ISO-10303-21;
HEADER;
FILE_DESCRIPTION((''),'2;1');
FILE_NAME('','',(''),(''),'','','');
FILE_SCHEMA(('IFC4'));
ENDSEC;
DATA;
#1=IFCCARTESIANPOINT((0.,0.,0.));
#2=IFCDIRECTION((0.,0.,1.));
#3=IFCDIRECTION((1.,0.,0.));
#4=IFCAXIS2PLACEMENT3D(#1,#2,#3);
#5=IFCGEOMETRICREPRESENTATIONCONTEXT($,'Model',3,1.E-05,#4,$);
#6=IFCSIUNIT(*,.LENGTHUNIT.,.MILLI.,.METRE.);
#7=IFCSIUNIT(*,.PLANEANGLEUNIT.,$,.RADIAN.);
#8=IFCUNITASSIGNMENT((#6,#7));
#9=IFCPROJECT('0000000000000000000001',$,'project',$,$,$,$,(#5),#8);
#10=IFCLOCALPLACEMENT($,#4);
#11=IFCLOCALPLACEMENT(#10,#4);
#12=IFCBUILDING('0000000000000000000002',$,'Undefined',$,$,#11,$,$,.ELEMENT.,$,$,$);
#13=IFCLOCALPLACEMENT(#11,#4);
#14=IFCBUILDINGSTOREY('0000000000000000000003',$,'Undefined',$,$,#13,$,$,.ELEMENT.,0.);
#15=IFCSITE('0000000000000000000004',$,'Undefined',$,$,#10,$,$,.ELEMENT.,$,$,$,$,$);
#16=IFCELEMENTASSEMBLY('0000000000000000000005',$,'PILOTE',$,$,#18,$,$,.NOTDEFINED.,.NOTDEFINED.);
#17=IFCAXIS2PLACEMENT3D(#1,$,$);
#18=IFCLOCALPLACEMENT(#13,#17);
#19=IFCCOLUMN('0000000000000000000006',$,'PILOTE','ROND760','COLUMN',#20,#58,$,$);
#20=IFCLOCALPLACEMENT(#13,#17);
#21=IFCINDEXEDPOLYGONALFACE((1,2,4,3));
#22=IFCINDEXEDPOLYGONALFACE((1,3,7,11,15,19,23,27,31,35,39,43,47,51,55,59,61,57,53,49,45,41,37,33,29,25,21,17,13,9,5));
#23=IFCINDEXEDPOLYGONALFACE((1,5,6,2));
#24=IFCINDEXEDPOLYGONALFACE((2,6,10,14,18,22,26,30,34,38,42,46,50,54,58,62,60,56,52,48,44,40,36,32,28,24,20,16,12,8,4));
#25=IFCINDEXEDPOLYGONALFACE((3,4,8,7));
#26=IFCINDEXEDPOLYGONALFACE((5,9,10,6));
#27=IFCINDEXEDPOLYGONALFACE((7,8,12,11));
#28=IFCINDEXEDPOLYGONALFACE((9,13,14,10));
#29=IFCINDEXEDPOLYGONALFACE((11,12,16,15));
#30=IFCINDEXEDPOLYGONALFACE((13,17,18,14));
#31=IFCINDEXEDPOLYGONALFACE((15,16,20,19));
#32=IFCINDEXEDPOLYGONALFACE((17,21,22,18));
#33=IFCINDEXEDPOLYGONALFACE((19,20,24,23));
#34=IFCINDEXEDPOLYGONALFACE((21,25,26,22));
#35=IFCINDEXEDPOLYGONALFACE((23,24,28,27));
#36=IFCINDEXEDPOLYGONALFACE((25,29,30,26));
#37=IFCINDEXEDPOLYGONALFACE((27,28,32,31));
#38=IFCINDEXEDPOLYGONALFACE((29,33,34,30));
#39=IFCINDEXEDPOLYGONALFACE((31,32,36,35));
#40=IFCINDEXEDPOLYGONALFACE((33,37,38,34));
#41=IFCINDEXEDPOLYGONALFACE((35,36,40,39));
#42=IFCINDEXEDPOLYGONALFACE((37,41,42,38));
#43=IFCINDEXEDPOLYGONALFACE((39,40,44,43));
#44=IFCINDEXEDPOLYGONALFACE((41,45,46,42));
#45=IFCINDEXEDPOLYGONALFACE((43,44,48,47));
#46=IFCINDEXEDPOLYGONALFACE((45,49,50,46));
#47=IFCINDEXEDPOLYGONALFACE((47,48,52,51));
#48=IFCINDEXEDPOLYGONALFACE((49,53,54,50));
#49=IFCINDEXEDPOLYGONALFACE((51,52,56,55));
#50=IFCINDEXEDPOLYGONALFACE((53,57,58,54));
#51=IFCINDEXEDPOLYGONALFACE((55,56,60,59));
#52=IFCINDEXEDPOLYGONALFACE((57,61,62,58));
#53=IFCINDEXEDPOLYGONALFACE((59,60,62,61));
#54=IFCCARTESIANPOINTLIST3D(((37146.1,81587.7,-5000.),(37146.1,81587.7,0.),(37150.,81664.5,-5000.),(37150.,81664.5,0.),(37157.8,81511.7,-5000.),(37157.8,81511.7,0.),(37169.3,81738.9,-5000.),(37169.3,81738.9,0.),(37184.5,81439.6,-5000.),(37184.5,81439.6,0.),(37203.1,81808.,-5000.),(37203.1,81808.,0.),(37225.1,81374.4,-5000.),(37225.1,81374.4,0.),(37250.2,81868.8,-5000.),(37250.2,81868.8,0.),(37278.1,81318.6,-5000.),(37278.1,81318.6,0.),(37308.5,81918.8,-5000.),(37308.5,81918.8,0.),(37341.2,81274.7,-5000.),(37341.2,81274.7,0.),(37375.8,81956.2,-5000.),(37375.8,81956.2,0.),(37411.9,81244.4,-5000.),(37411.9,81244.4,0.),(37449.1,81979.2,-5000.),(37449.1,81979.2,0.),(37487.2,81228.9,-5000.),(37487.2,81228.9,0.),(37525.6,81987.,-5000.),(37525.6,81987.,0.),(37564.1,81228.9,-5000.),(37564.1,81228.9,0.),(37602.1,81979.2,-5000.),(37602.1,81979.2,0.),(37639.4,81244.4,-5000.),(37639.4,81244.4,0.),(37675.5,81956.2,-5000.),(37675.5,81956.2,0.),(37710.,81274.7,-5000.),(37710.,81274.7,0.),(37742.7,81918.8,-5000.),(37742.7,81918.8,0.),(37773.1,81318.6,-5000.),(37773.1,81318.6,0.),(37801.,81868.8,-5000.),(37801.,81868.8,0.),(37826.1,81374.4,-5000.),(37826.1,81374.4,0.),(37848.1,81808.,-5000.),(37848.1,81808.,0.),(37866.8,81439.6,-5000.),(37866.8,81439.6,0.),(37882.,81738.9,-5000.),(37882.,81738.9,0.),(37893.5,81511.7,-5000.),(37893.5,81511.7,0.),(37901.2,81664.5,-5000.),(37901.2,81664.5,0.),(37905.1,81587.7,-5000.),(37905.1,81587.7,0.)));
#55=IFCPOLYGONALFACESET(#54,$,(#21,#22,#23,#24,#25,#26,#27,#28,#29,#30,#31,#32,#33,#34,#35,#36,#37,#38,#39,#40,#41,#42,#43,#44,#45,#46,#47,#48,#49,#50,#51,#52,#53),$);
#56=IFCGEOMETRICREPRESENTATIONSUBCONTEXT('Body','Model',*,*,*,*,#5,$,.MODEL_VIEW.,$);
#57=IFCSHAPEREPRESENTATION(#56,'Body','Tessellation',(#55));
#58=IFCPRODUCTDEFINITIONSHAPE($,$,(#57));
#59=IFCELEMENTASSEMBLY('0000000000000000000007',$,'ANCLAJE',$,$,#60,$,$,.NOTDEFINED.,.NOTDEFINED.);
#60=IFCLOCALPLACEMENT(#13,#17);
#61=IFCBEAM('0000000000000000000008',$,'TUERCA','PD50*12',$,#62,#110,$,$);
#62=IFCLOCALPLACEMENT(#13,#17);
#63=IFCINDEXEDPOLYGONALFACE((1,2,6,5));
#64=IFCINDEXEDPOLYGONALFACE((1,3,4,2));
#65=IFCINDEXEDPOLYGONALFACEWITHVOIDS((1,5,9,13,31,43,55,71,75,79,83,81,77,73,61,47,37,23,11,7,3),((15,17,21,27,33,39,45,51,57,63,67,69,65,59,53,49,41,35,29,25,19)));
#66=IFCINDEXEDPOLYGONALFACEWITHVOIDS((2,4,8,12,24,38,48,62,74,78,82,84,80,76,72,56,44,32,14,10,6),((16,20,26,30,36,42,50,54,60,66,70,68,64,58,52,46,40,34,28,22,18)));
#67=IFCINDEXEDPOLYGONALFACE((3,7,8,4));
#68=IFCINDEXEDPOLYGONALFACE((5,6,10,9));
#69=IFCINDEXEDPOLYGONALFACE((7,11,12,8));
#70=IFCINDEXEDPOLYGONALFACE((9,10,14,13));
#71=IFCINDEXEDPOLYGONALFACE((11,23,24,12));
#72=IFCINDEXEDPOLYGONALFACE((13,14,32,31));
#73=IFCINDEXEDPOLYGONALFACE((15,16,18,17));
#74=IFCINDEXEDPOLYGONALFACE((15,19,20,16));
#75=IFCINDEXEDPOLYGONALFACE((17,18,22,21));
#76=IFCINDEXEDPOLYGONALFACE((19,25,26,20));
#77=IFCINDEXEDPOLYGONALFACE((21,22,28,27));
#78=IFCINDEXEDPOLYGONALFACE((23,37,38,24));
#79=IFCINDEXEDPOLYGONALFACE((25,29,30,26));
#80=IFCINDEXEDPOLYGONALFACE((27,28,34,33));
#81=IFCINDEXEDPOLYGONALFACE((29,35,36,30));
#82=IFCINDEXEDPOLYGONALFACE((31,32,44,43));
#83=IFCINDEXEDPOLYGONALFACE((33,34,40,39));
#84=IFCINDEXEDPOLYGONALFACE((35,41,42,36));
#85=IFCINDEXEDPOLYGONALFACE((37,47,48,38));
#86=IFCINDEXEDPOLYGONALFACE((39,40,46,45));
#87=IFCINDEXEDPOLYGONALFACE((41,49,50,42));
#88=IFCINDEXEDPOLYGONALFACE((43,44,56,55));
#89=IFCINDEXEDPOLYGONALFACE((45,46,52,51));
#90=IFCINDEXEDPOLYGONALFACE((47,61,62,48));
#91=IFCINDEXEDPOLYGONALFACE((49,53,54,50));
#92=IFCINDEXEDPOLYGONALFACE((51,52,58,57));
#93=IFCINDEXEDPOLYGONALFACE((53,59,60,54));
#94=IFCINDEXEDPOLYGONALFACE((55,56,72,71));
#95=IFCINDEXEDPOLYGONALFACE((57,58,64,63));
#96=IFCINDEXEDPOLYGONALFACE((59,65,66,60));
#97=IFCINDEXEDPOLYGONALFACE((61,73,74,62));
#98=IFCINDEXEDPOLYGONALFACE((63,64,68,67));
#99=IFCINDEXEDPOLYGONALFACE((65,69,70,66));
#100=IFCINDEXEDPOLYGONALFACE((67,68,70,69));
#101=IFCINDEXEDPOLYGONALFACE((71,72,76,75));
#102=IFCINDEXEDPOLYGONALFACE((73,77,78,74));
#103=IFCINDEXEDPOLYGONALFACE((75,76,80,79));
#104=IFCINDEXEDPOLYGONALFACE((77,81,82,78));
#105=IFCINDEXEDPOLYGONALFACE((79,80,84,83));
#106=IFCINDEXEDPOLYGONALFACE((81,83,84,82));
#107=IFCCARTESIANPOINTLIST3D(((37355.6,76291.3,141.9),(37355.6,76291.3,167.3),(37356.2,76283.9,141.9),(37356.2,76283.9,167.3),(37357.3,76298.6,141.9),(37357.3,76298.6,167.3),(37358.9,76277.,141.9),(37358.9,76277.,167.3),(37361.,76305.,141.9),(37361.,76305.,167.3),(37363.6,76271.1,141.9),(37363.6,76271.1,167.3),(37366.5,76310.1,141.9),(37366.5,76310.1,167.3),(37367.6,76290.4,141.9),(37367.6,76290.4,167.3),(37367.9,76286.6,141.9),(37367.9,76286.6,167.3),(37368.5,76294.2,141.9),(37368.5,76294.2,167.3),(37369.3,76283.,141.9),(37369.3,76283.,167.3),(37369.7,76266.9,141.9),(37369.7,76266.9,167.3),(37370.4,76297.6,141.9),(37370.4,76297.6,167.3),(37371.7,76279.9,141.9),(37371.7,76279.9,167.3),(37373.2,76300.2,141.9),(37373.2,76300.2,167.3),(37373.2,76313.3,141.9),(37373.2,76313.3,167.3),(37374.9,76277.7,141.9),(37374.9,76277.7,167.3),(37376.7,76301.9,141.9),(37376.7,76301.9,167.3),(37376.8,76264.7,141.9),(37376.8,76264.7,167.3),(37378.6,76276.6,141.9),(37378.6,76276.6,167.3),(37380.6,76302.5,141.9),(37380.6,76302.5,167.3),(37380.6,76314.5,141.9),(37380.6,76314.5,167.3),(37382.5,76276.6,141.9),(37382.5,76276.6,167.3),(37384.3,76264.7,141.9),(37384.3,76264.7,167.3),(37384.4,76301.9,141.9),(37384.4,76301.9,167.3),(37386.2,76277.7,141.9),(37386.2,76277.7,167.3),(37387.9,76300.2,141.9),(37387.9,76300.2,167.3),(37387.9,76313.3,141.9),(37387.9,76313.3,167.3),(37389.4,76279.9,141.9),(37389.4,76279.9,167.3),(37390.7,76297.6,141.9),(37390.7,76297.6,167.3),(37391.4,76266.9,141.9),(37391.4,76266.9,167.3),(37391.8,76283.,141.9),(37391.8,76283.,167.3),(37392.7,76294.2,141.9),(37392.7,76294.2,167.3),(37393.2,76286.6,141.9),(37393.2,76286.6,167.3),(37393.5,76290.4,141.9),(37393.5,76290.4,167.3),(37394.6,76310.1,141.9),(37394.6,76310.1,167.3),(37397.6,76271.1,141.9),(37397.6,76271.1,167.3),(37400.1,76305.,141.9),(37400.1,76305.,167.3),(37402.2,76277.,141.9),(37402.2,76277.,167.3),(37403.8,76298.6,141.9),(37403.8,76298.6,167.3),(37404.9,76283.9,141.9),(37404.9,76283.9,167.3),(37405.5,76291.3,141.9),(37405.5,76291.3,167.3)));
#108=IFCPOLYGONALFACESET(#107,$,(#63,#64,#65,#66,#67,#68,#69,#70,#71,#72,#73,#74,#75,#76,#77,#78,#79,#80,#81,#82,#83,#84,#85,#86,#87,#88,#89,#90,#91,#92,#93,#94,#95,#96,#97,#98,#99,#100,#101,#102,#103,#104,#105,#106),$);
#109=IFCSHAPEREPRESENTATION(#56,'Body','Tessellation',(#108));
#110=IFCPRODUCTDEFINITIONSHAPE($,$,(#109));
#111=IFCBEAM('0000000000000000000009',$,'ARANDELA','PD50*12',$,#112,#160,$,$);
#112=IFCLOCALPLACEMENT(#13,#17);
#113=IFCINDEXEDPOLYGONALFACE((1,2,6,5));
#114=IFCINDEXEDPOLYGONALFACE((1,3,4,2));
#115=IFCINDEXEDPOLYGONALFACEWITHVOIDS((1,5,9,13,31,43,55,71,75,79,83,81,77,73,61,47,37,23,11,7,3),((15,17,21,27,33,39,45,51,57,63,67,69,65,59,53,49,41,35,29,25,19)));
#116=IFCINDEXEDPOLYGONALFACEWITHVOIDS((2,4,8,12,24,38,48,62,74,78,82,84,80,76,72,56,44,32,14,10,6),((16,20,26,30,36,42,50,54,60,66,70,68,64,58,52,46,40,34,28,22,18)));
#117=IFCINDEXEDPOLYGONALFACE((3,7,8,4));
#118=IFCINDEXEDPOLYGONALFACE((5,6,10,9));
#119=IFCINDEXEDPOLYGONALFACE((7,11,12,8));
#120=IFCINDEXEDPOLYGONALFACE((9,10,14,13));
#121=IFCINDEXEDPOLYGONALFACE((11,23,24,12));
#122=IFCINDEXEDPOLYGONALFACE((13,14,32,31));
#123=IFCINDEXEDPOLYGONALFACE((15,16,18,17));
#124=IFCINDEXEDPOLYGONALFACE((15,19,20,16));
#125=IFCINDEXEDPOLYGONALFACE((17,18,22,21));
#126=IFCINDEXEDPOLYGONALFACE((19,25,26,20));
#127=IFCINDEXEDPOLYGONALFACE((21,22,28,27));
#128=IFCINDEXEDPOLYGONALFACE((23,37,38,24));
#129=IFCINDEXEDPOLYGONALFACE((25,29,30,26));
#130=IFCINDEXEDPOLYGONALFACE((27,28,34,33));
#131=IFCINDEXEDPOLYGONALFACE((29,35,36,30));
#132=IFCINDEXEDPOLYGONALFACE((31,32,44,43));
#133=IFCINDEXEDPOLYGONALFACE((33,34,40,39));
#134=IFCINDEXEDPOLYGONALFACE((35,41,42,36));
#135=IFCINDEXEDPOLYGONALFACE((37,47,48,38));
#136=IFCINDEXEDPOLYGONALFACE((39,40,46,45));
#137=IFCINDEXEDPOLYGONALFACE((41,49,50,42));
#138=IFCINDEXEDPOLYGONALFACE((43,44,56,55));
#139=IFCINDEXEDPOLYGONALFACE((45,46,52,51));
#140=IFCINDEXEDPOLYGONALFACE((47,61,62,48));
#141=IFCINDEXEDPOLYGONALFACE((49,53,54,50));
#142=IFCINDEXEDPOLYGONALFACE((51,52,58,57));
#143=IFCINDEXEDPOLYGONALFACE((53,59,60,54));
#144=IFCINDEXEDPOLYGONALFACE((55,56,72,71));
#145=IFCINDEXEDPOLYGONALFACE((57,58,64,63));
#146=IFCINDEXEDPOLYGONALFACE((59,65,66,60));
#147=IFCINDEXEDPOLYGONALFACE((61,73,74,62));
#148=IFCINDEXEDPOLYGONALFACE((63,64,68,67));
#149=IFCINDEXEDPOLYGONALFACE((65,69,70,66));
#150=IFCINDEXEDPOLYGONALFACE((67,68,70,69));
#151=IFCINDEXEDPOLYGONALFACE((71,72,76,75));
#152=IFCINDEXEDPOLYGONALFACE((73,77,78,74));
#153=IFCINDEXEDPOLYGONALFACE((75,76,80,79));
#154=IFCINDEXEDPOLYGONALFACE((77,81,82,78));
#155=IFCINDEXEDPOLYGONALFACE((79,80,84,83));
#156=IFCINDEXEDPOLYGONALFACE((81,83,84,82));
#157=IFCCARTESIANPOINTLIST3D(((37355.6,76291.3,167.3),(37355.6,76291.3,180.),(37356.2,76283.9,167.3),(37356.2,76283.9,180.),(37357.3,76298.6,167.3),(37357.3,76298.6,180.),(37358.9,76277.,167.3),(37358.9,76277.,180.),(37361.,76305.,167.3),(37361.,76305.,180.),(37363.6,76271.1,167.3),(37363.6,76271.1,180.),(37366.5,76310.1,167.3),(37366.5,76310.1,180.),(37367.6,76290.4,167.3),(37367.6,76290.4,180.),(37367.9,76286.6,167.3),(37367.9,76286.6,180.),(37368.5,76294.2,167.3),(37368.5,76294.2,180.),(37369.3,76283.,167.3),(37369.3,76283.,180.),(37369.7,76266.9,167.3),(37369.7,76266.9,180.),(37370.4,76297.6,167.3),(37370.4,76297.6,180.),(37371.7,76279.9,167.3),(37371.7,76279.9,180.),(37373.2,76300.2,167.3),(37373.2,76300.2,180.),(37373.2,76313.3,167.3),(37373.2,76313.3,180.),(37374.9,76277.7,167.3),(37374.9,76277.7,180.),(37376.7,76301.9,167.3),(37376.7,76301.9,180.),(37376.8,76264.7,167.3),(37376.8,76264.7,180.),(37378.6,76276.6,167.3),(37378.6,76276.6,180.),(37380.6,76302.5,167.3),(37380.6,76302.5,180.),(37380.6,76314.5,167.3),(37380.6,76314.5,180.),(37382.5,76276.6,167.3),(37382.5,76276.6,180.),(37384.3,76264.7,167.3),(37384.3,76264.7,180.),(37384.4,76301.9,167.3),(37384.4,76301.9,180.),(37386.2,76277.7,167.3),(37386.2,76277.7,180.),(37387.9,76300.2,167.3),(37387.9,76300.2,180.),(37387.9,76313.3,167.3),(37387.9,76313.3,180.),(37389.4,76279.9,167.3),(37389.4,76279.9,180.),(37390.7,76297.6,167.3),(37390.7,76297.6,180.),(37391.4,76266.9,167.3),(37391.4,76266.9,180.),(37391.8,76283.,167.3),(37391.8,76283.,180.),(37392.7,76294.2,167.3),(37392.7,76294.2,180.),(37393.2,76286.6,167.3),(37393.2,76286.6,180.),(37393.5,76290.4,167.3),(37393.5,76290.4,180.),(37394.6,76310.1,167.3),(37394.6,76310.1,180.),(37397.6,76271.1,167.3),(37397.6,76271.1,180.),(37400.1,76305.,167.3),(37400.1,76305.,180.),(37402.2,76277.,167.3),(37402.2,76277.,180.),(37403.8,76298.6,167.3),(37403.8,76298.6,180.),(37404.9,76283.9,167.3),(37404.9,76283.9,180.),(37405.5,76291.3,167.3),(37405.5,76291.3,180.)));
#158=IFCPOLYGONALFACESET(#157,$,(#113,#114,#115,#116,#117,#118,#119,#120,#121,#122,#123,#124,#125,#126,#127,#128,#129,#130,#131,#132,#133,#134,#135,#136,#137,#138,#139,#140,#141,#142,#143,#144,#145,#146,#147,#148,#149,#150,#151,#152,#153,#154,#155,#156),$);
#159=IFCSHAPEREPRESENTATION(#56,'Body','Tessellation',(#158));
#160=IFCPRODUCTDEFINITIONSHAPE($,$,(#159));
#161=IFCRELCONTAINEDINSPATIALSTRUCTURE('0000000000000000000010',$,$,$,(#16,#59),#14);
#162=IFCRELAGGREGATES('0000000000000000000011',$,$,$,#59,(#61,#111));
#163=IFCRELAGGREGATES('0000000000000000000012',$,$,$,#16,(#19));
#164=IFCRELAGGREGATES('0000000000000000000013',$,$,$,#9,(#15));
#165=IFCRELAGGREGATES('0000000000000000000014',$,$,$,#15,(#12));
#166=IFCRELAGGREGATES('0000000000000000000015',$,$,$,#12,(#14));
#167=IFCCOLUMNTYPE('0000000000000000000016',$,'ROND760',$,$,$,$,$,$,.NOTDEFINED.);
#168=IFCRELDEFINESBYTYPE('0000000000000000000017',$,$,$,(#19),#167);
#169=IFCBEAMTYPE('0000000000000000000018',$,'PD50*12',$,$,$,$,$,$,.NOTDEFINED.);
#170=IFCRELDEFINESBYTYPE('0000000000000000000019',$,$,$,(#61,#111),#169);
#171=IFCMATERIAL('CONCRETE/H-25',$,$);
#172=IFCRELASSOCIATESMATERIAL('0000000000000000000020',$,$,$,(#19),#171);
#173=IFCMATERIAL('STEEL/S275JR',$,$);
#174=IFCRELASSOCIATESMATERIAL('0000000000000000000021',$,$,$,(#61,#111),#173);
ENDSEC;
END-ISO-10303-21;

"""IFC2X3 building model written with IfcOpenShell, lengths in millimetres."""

from ifc_helpers import new_model, si_unit, frame, origin_with_axes, origin_2d_with_axis, place, context, subcontext, project, spatial, circle, hollow_circle, extrude, material, type_object, element, aggregate, save


model = new_model("IFC2X3")

# Units and contexts
model_context = context("Model", 3, precision=1e-05, world=origin_with_axes())
body_context = subcontext(model_context, "Body", "Model", "MODEL_VIEW")
ifc_project = project(units=[si_unit("LENGTHUNIT", "METRE", prefix="MILLI"), si_unit("PLANEANGLEUNIT", "RADIAN")], contexts=[model_context])

# Site, building, storey
site_placement = place(None, origin_with_axes())
site = spatial("IfcSite", under=ifc_project, at=site_placement, Name="Undefined", CompositionType="ELEMENT")
building_placement = place(site_placement, origin_with_axes())
building = spatial("IfcBuilding", under=site, at=building_placement, Name="Undefined", CompositionType="ELEMENT")
storey_placement = place(building_placement, origin_with_axes())
storey = spatial("IfcBuildingStorey", under=building, at=storey_placement, Name="Undefined", CompositionType="ELEMENT", Elevation=0.0)

# Element assembly, column
assembly_1_placement = place(storey_placement, origin_with_axes())
assembly_1 = element("IfcElementAssembly", 1, at=assembly_1_placement, inside=storey, Name="PILOTE", AssemblyPlace="NOTDEFINED", PredefinedType="NOTDEFINED")
ifc_material_1 = material(Name="CONCRETE/H-25")
column_type = type_object("IfcColumnType", Name="ROND760", PredefinedType="NOTDEFINED")
column_placement = place(assembly_1_placement, frame((37525.6, 81607.0, 0.0), z_axis=(0.0, 0.0, -1.0), x_axis=(-1.0, 0.0, 0.0)))
column = element("IfcColumn", 2, at=column_placement, type_object=column_type, material=ifc_material_1, Name="PILOTE", Description="ROND760", ObjectType="COLUMN", context=body_context, shape_type="SweptSolid", body=[
    extrude(circle(Radius=380.0, at=origin_2d_with_axis()), frame((0.0, 0.0, 5000.0), z_axis=(0.0, 0.0, -1.0), x_axis=(0.0, 1.0, 0.0)), (0.0, 0.0, 1.0), 5000.0),
])

# Element assembly, beams
assembly_2_placement = place(storey_placement, origin_with_axes())
assembly_2 = element("IfcElementAssembly", 3, at=assembly_2_placement, inside=storey, Name="ANCLAJE", AssemblyPlace="NOTDEFINED", PredefinedType="NOTDEFINED")
ifc_material_2 = material(Name="STEEL/S275JR")
beam_type = type_object("IfcBeamType", Name="PD50*12", PredefinedType="NOTDEFINED")
beam_1_placement = place(assembly_2_placement, frame((37380.6, 76289.5, 167.3), z_axis=(-1.0, 0.0, 0.0), x_axis=(0.0, 0.0, -1.0)))
beam_1 = element("IfcBeam", 4, at=beam_1_placement, type_object=beam_type, material=ifc_material_2, Name="TUERCA", Description="PD50*12", context=body_context, shape_type="SweptSolid", body=[
    extrude(hollow_circle(Radius=25.0, WallThickness=12.0, at=origin_2d_with_axis()), frame((25.4, 0.0, 0.0), z_axis=(-1.0, 0.0, 0.0), x_axis=(0.0, -1.0, 0.0)), (0.0, 0.0, 1.0), 25.4),
])
beam_2_placement = place(assembly_2_placement, frame((37380.6, 76289.5, 180.0), z_axis=(-1.0, 0.0, 0.0), x_axis=(0.0, 0.0, -1.0)))
beam_2 = element("IfcBeam", 5, at=beam_2_placement, type_object=beam_type, material=ifc_material_2, Name="ARANDELA", Description="PD50*12", context=body_context, shape_type="SweptSolid", body=[
    extrude(hollow_circle(Radius=25.0, WallThickness=12.0, at=origin_2d_with_axis()), frame((12.7, 0.0, 0.0), z_axis=(-1.0, 0.0, 0.0), x_axis=(0.0, -1.0, 0.0)), (0.0, 0.0, 1.0), 12.7),
])

aggregate(assembly_2, [beam_1, beam_2])

aggregate(assembly_1, [column])

save(model, "model.ifc")
